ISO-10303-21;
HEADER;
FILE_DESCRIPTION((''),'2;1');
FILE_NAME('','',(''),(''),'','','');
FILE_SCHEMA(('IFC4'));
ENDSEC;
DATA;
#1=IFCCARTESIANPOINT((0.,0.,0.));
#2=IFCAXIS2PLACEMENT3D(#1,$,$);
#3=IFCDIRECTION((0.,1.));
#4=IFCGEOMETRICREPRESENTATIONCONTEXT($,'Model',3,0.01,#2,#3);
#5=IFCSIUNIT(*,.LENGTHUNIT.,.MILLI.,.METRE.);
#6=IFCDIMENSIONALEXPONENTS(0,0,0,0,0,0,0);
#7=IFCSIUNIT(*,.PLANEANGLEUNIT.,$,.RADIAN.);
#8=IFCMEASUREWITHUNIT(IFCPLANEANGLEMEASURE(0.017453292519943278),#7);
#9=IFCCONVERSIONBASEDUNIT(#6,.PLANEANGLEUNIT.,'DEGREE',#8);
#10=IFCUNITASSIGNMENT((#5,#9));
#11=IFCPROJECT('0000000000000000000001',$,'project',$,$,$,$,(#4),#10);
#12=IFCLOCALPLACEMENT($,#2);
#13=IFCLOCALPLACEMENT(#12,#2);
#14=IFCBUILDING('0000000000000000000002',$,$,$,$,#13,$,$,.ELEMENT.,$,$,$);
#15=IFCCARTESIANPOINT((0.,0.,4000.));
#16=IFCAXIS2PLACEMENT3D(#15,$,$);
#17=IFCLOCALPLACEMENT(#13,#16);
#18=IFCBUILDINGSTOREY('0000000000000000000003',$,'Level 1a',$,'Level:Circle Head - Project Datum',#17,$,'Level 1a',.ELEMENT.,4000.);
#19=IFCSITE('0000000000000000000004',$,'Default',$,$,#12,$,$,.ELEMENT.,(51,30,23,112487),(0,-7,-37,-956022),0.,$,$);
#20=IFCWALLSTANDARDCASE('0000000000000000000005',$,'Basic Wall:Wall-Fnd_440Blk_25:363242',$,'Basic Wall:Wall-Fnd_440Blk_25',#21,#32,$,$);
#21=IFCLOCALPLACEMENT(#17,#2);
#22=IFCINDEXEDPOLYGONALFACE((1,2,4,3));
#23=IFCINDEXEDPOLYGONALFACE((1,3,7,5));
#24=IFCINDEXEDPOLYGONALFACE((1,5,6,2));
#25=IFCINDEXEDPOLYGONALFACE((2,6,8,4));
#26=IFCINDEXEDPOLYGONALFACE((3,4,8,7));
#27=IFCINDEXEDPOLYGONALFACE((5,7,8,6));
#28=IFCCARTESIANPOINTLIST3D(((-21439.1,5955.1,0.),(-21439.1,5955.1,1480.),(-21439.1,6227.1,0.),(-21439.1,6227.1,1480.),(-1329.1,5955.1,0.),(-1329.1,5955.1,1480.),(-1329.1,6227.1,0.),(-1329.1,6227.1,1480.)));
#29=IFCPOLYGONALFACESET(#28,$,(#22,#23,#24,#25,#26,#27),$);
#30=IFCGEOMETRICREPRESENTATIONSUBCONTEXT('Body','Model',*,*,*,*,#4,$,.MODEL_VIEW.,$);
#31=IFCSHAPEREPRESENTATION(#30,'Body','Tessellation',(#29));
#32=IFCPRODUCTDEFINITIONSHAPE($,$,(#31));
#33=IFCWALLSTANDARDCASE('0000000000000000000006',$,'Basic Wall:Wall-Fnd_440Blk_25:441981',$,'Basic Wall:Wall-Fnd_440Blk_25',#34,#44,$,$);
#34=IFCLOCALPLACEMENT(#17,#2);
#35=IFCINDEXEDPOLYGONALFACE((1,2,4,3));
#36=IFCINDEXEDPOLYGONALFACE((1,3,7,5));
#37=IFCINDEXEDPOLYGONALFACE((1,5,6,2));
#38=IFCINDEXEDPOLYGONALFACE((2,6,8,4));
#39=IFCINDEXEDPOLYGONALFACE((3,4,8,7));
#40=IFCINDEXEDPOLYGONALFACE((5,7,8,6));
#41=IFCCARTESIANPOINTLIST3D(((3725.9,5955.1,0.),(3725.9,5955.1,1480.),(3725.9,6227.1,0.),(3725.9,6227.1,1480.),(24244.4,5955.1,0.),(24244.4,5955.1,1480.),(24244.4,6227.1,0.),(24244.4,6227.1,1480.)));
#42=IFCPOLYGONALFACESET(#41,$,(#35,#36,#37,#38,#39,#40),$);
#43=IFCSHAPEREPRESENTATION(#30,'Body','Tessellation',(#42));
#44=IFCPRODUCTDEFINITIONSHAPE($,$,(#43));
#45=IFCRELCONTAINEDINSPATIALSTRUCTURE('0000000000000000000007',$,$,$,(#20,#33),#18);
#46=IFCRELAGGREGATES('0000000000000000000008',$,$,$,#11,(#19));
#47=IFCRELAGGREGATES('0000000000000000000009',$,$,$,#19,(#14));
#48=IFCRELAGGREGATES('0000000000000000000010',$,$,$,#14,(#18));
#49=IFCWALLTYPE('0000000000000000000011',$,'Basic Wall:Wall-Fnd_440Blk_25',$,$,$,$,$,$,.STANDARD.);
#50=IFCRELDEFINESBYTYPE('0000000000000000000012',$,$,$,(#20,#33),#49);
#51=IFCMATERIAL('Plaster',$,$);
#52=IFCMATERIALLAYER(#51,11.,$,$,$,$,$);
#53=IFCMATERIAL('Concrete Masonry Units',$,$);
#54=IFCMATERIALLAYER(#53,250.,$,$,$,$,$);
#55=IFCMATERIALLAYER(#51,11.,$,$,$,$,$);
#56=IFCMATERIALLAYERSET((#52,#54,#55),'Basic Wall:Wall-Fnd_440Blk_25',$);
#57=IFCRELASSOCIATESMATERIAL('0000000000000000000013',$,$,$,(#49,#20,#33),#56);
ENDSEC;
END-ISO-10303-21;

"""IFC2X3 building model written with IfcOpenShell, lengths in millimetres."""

from ifc_helpers import new_model, entity, si_unit, converted_unit, direction, frame, frame_2d, origin, place, context, subcontext, project, spatial, rectangle, extrude, material, layer, layer_set, layer_usage, type_object, element, save


model = new_model("IFC2X3")

# Units and contexts
model_context = context("Model", 3, precision=0.01, world=origin(), true_north=direction((0.0, 1.0)))
body_context = subcontext(model_context, "Body", "Model", "MODEL_VIEW")
ifc_project = project(units=[si_unit("LENGTHUNIT", "METRE", prefix="MILLI"), converted_unit("PLANEANGLEUNIT", "DEGREE", entity("IfcPlaneAngleMeasure", 0.017453292519943278), si_unit("PLANEANGLEUNIT", "RADIAN"), dimensions=[0, 0, 0, 0, 0, 0, 0])], contexts=[model_context])

# Site, building, storey
site_placement = place(None, origin())
site = spatial("IfcSite", under=ifc_project, at=site_placement, Name="Default", CompositionType="ELEMENT", RefLatitude=(51, 30, 23, 112487), RefLongitude=(0, -7, -37, -956022), RefElevation=0.0)
building_placement = place(site_placement, origin())
building = spatial("IfcBuilding", under=site, at=building_placement, CompositionType="ELEMENT")
storey_placement = place(building_placement, frame((0.0, 0.0, 4000.0)))
storey = spatial("IfcBuildingStorey", under=building, at=storey_placement, Name="Level 1a", ObjectType="Level:Circle Head - Project Datum", LongName="Level 1a", CompositionType="ELEMENT", Elevation=4000.0)

# Walls
ifc_material_1 = material(Name="Plaster")
ifc_layer_1 = layer(ifc_material_1, 11.0)
ifc_material_2 = material(Name="Concrete Masonry Units")
ifc_layer_2 = layer(ifc_material_2, 250.0)
ifc_layer_3 = layer(ifc_material_1, 11.0)
ifc_layer_set = layer_set([ifc_layer_1, ifc_layer_2, ifc_layer_3], Name="Basic Wall:Wall-Fnd_440Blk_25")
ifc_layer_usage = layer_usage(ifc_layer_set, "AXIS2", "NEGATIVE", 136.0)
wall_type = type_object("IfcWallType", Name="Basic Wall:Wall-Fnd_440Blk_25", PredefinedType="STANDARD", material=ifc_layer_set)
wall_1_placement = place(storey_placement, frame((-1329.1, 6091.1, 0.0), z_axis=(0.0, 0.0, 1.0), x_axis=(-1.0, 0.0, 0.0)))
element("IfcWallStandardCase", 1, at=wall_1_placement, inside=storey, type_object=wall_type, material=ifc_layer_usage, Name="Basic Wall:Wall-Fnd_440Blk_25:363242", ObjectType="Basic Wall:Wall-Fnd_440Blk_25", context=body_context, shape_type="SweptSolid", body=[
    extrude(rectangle(XDim=20110.0, YDim=272.0, at=frame_2d((10055.0, 0.0), x_axis=(-1.0, 0.0))), origin(), (0.0, 0.0, 1.0), 1480.0),
])
wall_2_placement = place(storey_placement, frame((24244.4, 6091.1, 0.0), z_axis=(0.0, 0.0, 1.0), x_axis=(-1.0, 0.0, 0.0)))
element("IfcWallStandardCase", 2, at=wall_2_placement, inside=storey, type_object=wall_type, material=ifc_layer_usage, Name="Basic Wall:Wall-Fnd_440Blk_25:441981", ObjectType="Basic Wall:Wall-Fnd_440Blk_25", context=body_context, shape_type="SweptSolid", body=[
    extrude(rectangle(XDim=20518.5, YDim=272.0, at=frame_2d((10259.3, 0.0), x_axis=(-1.0, 0.0))), origin(), (0.0, 0.0, 1.0), 1480.0),
])

save(model, "model.ifc")
